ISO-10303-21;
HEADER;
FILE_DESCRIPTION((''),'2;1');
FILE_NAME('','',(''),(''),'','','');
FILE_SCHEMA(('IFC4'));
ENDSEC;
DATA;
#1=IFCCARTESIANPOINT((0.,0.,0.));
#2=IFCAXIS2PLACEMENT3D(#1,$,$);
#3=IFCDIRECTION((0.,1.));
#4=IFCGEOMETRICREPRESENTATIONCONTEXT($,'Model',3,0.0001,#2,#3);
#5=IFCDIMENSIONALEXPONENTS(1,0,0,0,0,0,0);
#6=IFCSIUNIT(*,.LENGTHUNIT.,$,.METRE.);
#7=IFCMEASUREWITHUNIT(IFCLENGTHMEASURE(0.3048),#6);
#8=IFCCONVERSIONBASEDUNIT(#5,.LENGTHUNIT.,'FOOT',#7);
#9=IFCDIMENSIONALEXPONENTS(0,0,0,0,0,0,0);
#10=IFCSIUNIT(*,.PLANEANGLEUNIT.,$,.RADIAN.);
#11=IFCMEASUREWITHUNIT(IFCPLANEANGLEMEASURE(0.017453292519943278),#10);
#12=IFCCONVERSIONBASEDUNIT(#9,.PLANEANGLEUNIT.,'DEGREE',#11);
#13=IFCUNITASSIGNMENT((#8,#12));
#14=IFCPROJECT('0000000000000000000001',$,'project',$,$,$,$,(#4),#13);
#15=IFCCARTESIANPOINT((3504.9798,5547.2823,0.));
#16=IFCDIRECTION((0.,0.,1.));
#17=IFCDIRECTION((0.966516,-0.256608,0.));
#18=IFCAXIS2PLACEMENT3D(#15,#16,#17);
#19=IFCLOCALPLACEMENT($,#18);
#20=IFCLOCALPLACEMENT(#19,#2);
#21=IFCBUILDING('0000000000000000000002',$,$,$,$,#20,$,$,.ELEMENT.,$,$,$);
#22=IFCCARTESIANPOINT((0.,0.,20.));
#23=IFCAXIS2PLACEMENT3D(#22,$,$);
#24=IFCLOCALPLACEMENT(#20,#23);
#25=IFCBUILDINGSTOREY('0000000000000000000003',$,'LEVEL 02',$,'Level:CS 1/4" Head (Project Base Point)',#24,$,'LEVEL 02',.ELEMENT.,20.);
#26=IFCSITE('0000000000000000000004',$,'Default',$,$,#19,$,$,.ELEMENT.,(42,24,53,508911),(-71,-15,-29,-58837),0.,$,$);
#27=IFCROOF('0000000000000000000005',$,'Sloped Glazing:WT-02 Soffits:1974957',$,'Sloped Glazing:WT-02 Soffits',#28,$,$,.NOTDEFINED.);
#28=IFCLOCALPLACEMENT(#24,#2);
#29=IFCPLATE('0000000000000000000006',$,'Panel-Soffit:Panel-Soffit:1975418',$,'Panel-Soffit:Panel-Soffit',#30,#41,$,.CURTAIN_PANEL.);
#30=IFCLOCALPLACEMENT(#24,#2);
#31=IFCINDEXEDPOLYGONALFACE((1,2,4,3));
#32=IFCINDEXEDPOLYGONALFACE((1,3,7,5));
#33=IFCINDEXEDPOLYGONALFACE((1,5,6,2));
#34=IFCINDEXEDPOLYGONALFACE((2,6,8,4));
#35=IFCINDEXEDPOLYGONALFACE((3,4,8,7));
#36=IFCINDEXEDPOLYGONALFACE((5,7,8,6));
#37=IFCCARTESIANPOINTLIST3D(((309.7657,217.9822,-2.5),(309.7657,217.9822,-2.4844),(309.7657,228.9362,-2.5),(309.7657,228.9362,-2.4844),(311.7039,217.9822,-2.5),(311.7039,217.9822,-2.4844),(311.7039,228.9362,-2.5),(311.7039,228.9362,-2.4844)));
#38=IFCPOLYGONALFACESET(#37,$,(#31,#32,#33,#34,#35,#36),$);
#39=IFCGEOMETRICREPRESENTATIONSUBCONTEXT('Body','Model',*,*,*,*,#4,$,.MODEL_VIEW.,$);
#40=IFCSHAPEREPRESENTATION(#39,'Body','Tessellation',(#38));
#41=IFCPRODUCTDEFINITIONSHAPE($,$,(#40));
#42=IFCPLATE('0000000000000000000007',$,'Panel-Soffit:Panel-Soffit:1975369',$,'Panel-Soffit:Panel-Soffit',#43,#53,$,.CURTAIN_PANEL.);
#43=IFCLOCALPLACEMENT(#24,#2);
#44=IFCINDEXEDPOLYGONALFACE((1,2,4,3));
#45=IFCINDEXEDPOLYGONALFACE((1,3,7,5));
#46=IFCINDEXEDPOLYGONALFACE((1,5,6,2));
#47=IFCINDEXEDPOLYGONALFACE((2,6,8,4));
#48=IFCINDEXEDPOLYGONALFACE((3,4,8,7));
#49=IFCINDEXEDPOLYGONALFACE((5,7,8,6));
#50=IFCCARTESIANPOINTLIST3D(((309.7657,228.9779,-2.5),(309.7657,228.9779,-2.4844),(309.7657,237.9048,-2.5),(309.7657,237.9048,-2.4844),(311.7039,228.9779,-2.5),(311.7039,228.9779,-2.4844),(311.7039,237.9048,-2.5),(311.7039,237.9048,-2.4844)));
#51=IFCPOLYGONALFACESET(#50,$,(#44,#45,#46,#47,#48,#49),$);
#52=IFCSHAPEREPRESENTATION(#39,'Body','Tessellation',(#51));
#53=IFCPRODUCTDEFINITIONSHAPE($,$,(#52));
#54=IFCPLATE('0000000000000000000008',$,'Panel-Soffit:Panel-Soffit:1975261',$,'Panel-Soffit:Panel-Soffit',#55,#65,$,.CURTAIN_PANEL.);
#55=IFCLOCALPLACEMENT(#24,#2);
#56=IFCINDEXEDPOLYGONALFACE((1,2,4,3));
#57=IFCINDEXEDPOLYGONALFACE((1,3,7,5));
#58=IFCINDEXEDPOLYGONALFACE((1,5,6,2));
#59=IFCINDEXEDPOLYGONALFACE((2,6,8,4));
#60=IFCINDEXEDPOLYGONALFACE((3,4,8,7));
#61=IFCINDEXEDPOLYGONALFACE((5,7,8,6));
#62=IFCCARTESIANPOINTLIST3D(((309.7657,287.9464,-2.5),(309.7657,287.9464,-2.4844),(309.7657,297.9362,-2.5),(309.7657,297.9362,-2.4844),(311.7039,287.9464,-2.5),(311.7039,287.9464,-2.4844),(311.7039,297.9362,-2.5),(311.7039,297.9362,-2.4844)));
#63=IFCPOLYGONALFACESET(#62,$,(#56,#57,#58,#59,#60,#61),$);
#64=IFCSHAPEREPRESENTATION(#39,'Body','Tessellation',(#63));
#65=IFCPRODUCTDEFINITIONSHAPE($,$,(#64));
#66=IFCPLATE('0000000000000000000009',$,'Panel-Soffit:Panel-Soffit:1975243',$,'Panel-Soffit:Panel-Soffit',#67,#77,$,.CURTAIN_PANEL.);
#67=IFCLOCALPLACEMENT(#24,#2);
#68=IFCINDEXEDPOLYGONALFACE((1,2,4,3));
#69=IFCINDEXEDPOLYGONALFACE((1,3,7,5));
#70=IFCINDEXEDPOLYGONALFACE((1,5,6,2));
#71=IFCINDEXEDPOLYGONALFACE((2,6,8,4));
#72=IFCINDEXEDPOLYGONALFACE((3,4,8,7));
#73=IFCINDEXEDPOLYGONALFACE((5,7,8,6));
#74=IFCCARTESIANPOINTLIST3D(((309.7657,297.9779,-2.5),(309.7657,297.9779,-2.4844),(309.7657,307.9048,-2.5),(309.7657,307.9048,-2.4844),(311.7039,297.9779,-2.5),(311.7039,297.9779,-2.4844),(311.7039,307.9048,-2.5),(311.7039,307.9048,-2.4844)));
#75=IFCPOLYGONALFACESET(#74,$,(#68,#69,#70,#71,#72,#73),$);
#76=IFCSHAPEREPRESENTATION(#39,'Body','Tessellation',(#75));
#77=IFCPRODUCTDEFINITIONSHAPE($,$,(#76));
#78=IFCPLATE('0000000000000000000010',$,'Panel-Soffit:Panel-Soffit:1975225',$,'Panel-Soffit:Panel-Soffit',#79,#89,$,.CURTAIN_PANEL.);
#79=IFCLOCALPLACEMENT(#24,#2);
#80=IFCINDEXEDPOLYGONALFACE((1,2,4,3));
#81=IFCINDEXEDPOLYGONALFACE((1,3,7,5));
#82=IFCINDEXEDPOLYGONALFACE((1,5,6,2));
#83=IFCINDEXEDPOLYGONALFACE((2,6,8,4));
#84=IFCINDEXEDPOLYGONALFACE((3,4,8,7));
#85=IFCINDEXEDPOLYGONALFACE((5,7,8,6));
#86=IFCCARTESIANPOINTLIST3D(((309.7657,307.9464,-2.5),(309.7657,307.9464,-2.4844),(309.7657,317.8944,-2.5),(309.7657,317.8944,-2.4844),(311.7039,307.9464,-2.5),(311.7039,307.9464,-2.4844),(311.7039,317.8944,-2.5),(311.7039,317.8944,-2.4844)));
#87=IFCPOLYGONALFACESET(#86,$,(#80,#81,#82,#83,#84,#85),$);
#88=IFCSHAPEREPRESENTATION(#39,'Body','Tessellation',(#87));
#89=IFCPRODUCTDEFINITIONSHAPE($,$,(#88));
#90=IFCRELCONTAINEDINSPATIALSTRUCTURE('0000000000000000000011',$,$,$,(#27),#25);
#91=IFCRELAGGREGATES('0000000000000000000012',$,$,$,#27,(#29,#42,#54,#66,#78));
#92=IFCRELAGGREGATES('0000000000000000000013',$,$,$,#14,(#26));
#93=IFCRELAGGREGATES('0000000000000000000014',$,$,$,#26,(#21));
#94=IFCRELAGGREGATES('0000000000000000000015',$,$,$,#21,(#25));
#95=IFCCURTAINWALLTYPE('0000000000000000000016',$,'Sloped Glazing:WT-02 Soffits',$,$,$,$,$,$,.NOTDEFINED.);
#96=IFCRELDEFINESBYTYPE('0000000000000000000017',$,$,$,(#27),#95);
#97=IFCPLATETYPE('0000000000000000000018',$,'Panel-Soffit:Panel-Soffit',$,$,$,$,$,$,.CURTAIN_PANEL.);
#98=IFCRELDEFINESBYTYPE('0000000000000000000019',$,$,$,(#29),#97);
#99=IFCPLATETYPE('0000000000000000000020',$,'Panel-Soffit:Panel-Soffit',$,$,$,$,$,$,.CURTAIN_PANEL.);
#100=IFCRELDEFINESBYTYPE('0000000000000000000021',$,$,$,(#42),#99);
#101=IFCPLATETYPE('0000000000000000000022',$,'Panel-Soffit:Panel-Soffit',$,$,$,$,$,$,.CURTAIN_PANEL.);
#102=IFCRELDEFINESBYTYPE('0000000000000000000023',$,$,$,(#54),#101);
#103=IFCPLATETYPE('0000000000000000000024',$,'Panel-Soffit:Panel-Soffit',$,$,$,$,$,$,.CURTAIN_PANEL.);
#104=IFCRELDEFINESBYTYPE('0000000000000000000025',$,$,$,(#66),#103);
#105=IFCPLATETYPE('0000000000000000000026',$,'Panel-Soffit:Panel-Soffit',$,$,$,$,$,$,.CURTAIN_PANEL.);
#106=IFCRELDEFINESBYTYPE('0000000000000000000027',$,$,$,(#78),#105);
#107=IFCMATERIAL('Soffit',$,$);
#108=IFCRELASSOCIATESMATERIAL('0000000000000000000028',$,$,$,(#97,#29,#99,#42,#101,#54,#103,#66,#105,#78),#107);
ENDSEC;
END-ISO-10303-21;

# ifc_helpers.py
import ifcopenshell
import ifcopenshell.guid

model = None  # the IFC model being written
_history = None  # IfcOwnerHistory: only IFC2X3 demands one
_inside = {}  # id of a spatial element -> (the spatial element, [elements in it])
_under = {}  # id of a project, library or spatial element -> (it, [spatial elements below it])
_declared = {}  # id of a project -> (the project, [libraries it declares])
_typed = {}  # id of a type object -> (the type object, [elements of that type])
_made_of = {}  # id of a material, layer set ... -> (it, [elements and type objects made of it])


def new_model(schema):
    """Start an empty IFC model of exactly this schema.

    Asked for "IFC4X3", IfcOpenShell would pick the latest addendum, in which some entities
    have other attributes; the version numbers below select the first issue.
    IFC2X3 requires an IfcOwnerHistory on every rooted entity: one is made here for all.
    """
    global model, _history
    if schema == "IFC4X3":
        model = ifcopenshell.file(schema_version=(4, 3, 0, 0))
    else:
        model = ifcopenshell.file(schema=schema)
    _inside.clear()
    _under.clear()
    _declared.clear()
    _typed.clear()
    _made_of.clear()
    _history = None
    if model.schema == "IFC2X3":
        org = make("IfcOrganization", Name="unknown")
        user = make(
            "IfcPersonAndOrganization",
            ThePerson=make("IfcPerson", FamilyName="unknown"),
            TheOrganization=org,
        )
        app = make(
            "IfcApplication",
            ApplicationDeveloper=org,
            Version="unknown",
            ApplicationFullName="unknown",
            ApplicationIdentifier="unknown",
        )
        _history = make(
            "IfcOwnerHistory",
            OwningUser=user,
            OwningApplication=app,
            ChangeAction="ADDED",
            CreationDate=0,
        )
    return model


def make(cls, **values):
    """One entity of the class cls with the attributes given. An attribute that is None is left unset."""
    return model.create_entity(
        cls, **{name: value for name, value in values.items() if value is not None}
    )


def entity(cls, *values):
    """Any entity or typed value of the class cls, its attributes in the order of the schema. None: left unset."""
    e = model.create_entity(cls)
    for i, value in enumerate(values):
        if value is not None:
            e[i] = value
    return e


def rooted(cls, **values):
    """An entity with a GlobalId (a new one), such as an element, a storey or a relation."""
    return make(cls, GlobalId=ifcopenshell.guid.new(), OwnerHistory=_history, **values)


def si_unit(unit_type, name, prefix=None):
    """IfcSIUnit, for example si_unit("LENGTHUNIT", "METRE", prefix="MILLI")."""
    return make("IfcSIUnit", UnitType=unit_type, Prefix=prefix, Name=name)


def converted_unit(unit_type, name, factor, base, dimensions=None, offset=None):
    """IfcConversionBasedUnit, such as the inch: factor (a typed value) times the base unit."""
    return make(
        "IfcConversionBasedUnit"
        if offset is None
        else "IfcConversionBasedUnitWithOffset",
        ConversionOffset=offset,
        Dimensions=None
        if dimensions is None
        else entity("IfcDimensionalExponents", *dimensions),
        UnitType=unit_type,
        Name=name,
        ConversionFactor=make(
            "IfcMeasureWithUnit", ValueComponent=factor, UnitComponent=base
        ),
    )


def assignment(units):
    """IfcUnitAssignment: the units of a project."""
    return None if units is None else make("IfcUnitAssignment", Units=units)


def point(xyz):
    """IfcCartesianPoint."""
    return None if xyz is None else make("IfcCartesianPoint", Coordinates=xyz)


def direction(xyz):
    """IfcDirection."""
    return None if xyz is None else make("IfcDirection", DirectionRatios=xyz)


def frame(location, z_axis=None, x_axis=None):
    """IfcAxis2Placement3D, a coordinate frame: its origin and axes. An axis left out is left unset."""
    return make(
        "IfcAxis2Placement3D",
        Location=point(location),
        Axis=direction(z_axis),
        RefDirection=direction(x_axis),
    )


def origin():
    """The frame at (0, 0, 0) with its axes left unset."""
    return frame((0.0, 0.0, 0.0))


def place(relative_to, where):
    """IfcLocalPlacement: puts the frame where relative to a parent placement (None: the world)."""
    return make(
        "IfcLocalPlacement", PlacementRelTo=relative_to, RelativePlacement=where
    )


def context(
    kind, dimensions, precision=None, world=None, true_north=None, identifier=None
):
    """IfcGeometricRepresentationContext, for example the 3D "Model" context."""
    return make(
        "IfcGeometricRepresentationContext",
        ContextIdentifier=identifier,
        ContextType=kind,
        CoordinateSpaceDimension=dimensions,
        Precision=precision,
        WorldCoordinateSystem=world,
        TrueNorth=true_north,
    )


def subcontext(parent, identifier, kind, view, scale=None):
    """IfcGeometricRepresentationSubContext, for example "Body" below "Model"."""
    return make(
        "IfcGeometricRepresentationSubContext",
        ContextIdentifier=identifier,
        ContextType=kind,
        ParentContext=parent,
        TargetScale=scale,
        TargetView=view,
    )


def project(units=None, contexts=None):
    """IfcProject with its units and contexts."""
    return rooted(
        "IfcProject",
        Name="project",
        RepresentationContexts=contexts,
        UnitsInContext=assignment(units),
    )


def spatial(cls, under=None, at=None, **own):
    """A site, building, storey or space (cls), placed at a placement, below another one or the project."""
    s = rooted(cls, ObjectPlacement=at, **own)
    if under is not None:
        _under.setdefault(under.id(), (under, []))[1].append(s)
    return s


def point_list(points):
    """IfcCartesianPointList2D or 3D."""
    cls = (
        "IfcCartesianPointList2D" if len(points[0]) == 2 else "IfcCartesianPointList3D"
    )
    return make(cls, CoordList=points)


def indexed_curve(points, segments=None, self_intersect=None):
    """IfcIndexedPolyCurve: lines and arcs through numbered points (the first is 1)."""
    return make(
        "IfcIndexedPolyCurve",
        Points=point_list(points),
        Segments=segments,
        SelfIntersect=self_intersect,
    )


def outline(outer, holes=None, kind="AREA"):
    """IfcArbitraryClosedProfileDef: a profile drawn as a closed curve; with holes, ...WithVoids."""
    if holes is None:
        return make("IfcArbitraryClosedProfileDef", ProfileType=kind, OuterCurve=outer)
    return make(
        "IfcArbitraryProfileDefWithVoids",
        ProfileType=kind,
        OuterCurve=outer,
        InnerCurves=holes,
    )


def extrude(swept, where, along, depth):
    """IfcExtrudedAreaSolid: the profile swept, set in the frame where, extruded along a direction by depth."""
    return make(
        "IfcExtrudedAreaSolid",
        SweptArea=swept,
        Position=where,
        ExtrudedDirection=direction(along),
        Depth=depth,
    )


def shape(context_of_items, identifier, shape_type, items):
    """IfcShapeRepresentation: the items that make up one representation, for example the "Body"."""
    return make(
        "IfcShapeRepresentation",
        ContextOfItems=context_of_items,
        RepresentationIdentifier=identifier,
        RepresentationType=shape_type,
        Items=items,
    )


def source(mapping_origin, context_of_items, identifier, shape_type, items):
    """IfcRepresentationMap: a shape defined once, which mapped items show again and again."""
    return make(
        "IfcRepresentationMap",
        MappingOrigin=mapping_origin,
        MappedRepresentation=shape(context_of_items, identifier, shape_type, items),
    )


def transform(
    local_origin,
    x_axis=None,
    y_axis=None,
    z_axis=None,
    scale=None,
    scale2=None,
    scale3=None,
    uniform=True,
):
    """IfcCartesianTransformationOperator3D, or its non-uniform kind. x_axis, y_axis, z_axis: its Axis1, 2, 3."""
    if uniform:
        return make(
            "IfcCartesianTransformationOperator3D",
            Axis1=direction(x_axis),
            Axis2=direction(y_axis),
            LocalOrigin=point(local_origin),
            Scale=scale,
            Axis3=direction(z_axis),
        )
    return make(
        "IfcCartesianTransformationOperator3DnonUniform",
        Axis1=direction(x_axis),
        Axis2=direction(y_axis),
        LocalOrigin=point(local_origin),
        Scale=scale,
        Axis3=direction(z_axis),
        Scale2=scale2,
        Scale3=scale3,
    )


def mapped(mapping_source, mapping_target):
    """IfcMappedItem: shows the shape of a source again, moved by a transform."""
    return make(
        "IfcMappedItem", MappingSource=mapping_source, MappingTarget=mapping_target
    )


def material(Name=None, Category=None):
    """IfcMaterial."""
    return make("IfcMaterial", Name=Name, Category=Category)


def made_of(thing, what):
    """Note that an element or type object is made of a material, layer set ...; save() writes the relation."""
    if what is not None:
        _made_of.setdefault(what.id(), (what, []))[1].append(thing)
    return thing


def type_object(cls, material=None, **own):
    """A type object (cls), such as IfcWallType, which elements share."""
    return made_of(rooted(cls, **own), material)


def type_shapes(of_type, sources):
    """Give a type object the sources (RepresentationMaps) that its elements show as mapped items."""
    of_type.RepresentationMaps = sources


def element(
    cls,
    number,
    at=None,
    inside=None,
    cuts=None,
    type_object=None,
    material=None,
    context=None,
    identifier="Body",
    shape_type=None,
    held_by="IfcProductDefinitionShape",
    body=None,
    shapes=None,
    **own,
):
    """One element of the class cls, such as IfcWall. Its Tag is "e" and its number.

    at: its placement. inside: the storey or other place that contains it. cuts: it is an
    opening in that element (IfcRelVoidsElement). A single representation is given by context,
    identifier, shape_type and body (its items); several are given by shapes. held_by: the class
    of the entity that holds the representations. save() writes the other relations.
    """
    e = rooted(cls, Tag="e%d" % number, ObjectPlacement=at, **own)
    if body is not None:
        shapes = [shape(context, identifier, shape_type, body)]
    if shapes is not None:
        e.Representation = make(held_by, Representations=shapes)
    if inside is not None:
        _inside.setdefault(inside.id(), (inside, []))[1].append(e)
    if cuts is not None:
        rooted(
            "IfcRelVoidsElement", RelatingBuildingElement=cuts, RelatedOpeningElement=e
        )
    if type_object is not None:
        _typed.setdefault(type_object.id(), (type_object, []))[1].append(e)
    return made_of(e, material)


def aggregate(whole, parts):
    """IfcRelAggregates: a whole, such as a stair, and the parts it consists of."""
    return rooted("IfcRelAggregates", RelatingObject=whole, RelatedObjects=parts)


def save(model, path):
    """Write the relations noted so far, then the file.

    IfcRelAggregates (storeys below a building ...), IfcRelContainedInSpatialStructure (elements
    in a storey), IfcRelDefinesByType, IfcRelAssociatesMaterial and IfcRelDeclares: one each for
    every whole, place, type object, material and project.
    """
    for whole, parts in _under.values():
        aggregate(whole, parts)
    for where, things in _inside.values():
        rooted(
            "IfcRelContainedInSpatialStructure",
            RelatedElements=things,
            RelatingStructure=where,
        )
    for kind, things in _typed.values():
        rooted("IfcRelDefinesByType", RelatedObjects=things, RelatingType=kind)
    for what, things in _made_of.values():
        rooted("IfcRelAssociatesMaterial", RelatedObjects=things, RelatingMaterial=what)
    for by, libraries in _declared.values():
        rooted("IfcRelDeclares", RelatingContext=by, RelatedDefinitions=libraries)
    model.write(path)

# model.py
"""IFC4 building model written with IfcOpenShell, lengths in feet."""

from ifc_helpers import new_model, entity, si_unit, converted_unit, direction, frame, origin, place, context, subcontext, project, spatial, indexed_curve, outline, extrude, source, transform, mapped, material, type_object, type_shapes, element, aggregate, save


model = new_model("IFC4")

# Units and contexts
model_context = context("Model", 3, precision=0.0001, world=origin(), true_north=direction((0.0, 1.0)))
body_context = subcontext(model_context, "Body", "Model", "MODEL_VIEW")
ifc_project = project(units=[converted_unit("LENGTHUNIT", "FOOT", entity("IfcLengthMeasure", 0.3048), si_unit("LENGTHUNIT", "METRE"), dimensions=[1, 0, 0, 0, 0, 0, 0]), converted_unit("PLANEANGLEUNIT", "DEGREE", entity("IfcPlaneAngleMeasure", 0.017453292519943278), si_unit("PLANEANGLEUNIT", "RADIAN"), dimensions=[0, 0, 0, 0, 0, 0, 0])], contexts=[model_context])

# Site, building, storey
site_placement = place(None, frame((3504.9798, 5547.2823, 0.0), z_axis=(0.0, 0.0, 1.0), x_axis=(0.966516, -0.256608, 0.0)))
site = spatial("IfcSite", under=ifc_project, at=site_placement, Name="Default", CompositionType="ELEMENT", RefLatitude=(42, 24, 53, 508911), RefLongitude=(-71, -15, -29, -58837), RefElevation=0.0)
building_placement = place(site_placement, origin())
building = spatial("IfcBuilding", under=site, at=building_placement, CompositionType="ELEMENT")
storey_placement = place(building_placement, frame((0.0, 0.0, 20.0)))
storey = spatial("IfcBuildingStorey", under=building, at=storey_placement, Name="LEVEL 02", ObjectType="Level:CS 1/4\" Head (Project Base Point)", LongName="LEVEL 02", CompositionType="ELEMENT", Elevation=20.0)

# Shared definitions
curtain_wall_type_1 = type_object("IfcCurtainWallType", Name="Sloped Glazing:WT-02 Soffits", PredefinedType="NOTDEFINED")
ifc_material_1 = material(Name="Soffit")

# Roof, plates
roof_1_placement = place(storey_placement, frame((0.0, 0.0, -20.0)))
roof_1 = element("IfcRoof", 1, at=roof_1_placement, inside=storey, type_object=curtain_wall_type_1, Name="Sloped Glazing:WT-02 Soffits:1974957", ObjectType="Sloped Glazing:WT-02 Soffits", PredefinedType="NOTDEFINED")
plate_type_1 = type_object("IfcPlateType", Name="Panel-Soffit:Panel-Soffit", PredefinedType="CURTAIN_PANEL", material=ifc_material_1)
shared_shape_1 = source(origin(), body_context, "Body", "SweptSolid", [
    extrude(outline(indexed_curve([(-0.0078, -0.9691), (0.0078, -0.9691), (0.0078, 0.9691), (-0.0078, 0.9691), (-0.0078, -0.9691)], self_intersect=False)), frame((0.0, -0.0078, 0.0208), z_axis=(0.0, 0.0, 1.0), x_axis=(0.0, -1.0, 0.0)), (0.0, 0.0, 1.0), 10.954),
])
type_shapes(plate_type_1, [shared_shape_1])
plate_1_placement = place(roof_1_placement, frame((310.7348, 217.9613, 17.5), z_axis=(0.0, 1.0, 0.0), x_axis=(1.0, 0.0, 0.0)))
plate_1 = element("IfcPlate", 2, at=plate_1_placement, type_object=plate_type_1, material=ifc_material_1, Name="Panel-Soffit:Panel-Soffit:1975418", ObjectType="Panel-Soffit:Panel-Soffit", PredefinedType="CURTAIN_PANEL", context=body_context, shape_type="MappedRepresentation", body=[
    mapped(shared_shape_1, transform((0.0, 0.0, 0.0), scale=1.0)),
])
plate_type_2 = type_object("IfcPlateType", Name="Panel-Soffit:Panel-Soffit", PredefinedType="CURTAIN_PANEL", material=ifc_material_1)
shared_shape_2 = source(origin(), body_context, "Body", "SweptSolid", [
    extrude(outline(indexed_curve([(-0.0078, -0.9691), (0.0078, -0.9691), (0.0078, 0.9691), (-0.0078, 0.9691), (-0.0078, -0.9691)], self_intersect=False)), frame((0.0, -0.0078, 0.0208), z_axis=(0.0, 0.0, 1.0), x_axis=(0.0, -1.0, 0.0)), (0.0, 0.0, 1.0), 8.9269),
])
type_shapes(plate_type_2, [shared_shape_2])
plate_2_placement = place(roof_1_placement, frame((310.7348, 228.957, 17.5), z_axis=(0.0, 1.0, 0.0), x_axis=(1.0, 0.0, 0.0)))
plate_2 = element("IfcPlate", 3, at=plate_2_placement, type_object=plate_type_2, material=ifc_material_1, Name="Panel-Soffit:Panel-Soffit:1975369", ObjectType="Panel-Soffit:Panel-Soffit", PredefinedType="CURTAIN_PANEL", context=body_context, shape_type="MappedRepresentation", body=[
    mapped(shared_shape_2, transform((0.0, 0.0, 0.0), scale=1.0)),
])
plate_type_3 = type_object("IfcPlateType", Name="Panel-Soffit:Panel-Soffit", PredefinedType="CURTAIN_PANEL", material=ifc_material_1)
shared_shape_3 = source(origin(), body_context, "Body", "SweptSolid", [
    extrude(outline(indexed_curve([(-0.0078, -0.9691), (0.0078, -0.9691), (0.0078, 0.9691), (-0.0078, 0.9691), (-0.0078, -0.9691)], self_intersect=False)), frame((0.0, -0.0078, 0.0208), z_axis=(0.0, 0.0, 1.0), x_axis=(0.0, -1.0, 0.0)), (0.0, 0.0, 1.0), 9.9898),
])
type_shapes(plate_type_3, [shared_shape_3])
plate_3_placement = place(roof_1_placement, frame((310.7348, 287.9256, 17.5), z_axis=(0.0, 1.0, 0.0), x_axis=(1.0, 0.0, 0.0)))
plate_3 = element("IfcPlate", 4, at=plate_3_placement, type_object=plate_type_3, material=ifc_material_1, Name="Panel-Soffit:Panel-Soffit:1975261", ObjectType="Panel-Soffit:Panel-Soffit", PredefinedType="CURTAIN_PANEL", context=body_context, shape_type="MappedRepresentation", body=[
    mapped(shared_shape_3, transform((0.0, 0.0, 0.0), scale=1.0)),
])
plate_type_4 = type_object("IfcPlateType", Name="Panel-Soffit:Panel-Soffit", PredefinedType="CURTAIN_PANEL", material=ifc_material_1)
shared_shape_4 = source(origin(), body_context, "Body", "SweptSolid", [
    extrude(outline(indexed_curve([(-0.0078, -0.9691), (0.0078, -0.9691), (0.0078, 0.9691), (-0.0078, 0.9691), (-0.0078, -0.9691)], self_intersect=False)), frame((0.0, -0.0078, 0.0208), z_axis=(0.0, 0.0, 1.0), x_axis=(0.0, -1.0, 0.0)), (0.0, 0.0, 1.0), 9.9269),
])
type_shapes(plate_type_4, [shared_shape_4])
plate_4_placement = place(roof_1_placement, frame((310.7348, 297.957, 17.5), z_axis=(0.0, 1.0, 0.0), x_axis=(1.0, 0.0, 0.0)))
plate_4 = element("IfcPlate", 5, at=plate_4_placement, type_object=plate_type_4, material=ifc_material_1, Name="Panel-Soffit:Panel-Soffit:1975243", ObjectType="Panel-Soffit:Panel-Soffit", PredefinedType="CURTAIN_PANEL", context=body_context, shape_type="MappedRepresentation", body=[
    mapped(shared_shape_4, transform((0.0, 0.0, 0.0), scale=1.0)),
])
plate_type_5 = type_object("IfcPlateType", Name="Panel-Soffit:Panel-Soffit", PredefinedType="CURTAIN_PANEL", material=ifc_material_1)
shared_shape_5 = source(origin(), body_context, "Body", "SweptSolid", [
    extrude(outline(indexed_curve([(-0.0078, -0.9691), (0.0078, -0.9691), (0.0078, 0.9691), (-0.0078, 0.9691), (-0.0078, -0.9691)], self_intersect=False)), frame((0.0, -0.0078, 0.0208), z_axis=(0.0, 0.0, 1.0), x_axis=(0.0, -1.0, 0.0)), (0.0, 0.0, 1.0), 9.948),
])
type_shapes(plate_type_5, [shared_shape_5])
plate_5_placement = place(roof_1_placement, frame((310.7348, 307.9256, 17.5), z_axis=(0.0, 1.0, 0.0), x_axis=(1.0, 0.0, 0.0)))
plate_5 = element("IfcPlate", 6, at=plate_5_placement, type_object=plate_type_5, material=ifc_material_1, Name="Panel-Soffit:Panel-Soffit:1975225", ObjectType="Panel-Soffit:Panel-Soffit", PredefinedType="CURTAIN_PANEL", context=body_context, shape_type="MappedRepresentation", body=[
    mapped(shared_shape_5, transform((0.0, 0.0, 0.0), scale=1.0)),
])
aggregate(roof_1, [plate_1, plate_2, plate_3, plate_4, plate_5])

save(model, "model.ifc")
